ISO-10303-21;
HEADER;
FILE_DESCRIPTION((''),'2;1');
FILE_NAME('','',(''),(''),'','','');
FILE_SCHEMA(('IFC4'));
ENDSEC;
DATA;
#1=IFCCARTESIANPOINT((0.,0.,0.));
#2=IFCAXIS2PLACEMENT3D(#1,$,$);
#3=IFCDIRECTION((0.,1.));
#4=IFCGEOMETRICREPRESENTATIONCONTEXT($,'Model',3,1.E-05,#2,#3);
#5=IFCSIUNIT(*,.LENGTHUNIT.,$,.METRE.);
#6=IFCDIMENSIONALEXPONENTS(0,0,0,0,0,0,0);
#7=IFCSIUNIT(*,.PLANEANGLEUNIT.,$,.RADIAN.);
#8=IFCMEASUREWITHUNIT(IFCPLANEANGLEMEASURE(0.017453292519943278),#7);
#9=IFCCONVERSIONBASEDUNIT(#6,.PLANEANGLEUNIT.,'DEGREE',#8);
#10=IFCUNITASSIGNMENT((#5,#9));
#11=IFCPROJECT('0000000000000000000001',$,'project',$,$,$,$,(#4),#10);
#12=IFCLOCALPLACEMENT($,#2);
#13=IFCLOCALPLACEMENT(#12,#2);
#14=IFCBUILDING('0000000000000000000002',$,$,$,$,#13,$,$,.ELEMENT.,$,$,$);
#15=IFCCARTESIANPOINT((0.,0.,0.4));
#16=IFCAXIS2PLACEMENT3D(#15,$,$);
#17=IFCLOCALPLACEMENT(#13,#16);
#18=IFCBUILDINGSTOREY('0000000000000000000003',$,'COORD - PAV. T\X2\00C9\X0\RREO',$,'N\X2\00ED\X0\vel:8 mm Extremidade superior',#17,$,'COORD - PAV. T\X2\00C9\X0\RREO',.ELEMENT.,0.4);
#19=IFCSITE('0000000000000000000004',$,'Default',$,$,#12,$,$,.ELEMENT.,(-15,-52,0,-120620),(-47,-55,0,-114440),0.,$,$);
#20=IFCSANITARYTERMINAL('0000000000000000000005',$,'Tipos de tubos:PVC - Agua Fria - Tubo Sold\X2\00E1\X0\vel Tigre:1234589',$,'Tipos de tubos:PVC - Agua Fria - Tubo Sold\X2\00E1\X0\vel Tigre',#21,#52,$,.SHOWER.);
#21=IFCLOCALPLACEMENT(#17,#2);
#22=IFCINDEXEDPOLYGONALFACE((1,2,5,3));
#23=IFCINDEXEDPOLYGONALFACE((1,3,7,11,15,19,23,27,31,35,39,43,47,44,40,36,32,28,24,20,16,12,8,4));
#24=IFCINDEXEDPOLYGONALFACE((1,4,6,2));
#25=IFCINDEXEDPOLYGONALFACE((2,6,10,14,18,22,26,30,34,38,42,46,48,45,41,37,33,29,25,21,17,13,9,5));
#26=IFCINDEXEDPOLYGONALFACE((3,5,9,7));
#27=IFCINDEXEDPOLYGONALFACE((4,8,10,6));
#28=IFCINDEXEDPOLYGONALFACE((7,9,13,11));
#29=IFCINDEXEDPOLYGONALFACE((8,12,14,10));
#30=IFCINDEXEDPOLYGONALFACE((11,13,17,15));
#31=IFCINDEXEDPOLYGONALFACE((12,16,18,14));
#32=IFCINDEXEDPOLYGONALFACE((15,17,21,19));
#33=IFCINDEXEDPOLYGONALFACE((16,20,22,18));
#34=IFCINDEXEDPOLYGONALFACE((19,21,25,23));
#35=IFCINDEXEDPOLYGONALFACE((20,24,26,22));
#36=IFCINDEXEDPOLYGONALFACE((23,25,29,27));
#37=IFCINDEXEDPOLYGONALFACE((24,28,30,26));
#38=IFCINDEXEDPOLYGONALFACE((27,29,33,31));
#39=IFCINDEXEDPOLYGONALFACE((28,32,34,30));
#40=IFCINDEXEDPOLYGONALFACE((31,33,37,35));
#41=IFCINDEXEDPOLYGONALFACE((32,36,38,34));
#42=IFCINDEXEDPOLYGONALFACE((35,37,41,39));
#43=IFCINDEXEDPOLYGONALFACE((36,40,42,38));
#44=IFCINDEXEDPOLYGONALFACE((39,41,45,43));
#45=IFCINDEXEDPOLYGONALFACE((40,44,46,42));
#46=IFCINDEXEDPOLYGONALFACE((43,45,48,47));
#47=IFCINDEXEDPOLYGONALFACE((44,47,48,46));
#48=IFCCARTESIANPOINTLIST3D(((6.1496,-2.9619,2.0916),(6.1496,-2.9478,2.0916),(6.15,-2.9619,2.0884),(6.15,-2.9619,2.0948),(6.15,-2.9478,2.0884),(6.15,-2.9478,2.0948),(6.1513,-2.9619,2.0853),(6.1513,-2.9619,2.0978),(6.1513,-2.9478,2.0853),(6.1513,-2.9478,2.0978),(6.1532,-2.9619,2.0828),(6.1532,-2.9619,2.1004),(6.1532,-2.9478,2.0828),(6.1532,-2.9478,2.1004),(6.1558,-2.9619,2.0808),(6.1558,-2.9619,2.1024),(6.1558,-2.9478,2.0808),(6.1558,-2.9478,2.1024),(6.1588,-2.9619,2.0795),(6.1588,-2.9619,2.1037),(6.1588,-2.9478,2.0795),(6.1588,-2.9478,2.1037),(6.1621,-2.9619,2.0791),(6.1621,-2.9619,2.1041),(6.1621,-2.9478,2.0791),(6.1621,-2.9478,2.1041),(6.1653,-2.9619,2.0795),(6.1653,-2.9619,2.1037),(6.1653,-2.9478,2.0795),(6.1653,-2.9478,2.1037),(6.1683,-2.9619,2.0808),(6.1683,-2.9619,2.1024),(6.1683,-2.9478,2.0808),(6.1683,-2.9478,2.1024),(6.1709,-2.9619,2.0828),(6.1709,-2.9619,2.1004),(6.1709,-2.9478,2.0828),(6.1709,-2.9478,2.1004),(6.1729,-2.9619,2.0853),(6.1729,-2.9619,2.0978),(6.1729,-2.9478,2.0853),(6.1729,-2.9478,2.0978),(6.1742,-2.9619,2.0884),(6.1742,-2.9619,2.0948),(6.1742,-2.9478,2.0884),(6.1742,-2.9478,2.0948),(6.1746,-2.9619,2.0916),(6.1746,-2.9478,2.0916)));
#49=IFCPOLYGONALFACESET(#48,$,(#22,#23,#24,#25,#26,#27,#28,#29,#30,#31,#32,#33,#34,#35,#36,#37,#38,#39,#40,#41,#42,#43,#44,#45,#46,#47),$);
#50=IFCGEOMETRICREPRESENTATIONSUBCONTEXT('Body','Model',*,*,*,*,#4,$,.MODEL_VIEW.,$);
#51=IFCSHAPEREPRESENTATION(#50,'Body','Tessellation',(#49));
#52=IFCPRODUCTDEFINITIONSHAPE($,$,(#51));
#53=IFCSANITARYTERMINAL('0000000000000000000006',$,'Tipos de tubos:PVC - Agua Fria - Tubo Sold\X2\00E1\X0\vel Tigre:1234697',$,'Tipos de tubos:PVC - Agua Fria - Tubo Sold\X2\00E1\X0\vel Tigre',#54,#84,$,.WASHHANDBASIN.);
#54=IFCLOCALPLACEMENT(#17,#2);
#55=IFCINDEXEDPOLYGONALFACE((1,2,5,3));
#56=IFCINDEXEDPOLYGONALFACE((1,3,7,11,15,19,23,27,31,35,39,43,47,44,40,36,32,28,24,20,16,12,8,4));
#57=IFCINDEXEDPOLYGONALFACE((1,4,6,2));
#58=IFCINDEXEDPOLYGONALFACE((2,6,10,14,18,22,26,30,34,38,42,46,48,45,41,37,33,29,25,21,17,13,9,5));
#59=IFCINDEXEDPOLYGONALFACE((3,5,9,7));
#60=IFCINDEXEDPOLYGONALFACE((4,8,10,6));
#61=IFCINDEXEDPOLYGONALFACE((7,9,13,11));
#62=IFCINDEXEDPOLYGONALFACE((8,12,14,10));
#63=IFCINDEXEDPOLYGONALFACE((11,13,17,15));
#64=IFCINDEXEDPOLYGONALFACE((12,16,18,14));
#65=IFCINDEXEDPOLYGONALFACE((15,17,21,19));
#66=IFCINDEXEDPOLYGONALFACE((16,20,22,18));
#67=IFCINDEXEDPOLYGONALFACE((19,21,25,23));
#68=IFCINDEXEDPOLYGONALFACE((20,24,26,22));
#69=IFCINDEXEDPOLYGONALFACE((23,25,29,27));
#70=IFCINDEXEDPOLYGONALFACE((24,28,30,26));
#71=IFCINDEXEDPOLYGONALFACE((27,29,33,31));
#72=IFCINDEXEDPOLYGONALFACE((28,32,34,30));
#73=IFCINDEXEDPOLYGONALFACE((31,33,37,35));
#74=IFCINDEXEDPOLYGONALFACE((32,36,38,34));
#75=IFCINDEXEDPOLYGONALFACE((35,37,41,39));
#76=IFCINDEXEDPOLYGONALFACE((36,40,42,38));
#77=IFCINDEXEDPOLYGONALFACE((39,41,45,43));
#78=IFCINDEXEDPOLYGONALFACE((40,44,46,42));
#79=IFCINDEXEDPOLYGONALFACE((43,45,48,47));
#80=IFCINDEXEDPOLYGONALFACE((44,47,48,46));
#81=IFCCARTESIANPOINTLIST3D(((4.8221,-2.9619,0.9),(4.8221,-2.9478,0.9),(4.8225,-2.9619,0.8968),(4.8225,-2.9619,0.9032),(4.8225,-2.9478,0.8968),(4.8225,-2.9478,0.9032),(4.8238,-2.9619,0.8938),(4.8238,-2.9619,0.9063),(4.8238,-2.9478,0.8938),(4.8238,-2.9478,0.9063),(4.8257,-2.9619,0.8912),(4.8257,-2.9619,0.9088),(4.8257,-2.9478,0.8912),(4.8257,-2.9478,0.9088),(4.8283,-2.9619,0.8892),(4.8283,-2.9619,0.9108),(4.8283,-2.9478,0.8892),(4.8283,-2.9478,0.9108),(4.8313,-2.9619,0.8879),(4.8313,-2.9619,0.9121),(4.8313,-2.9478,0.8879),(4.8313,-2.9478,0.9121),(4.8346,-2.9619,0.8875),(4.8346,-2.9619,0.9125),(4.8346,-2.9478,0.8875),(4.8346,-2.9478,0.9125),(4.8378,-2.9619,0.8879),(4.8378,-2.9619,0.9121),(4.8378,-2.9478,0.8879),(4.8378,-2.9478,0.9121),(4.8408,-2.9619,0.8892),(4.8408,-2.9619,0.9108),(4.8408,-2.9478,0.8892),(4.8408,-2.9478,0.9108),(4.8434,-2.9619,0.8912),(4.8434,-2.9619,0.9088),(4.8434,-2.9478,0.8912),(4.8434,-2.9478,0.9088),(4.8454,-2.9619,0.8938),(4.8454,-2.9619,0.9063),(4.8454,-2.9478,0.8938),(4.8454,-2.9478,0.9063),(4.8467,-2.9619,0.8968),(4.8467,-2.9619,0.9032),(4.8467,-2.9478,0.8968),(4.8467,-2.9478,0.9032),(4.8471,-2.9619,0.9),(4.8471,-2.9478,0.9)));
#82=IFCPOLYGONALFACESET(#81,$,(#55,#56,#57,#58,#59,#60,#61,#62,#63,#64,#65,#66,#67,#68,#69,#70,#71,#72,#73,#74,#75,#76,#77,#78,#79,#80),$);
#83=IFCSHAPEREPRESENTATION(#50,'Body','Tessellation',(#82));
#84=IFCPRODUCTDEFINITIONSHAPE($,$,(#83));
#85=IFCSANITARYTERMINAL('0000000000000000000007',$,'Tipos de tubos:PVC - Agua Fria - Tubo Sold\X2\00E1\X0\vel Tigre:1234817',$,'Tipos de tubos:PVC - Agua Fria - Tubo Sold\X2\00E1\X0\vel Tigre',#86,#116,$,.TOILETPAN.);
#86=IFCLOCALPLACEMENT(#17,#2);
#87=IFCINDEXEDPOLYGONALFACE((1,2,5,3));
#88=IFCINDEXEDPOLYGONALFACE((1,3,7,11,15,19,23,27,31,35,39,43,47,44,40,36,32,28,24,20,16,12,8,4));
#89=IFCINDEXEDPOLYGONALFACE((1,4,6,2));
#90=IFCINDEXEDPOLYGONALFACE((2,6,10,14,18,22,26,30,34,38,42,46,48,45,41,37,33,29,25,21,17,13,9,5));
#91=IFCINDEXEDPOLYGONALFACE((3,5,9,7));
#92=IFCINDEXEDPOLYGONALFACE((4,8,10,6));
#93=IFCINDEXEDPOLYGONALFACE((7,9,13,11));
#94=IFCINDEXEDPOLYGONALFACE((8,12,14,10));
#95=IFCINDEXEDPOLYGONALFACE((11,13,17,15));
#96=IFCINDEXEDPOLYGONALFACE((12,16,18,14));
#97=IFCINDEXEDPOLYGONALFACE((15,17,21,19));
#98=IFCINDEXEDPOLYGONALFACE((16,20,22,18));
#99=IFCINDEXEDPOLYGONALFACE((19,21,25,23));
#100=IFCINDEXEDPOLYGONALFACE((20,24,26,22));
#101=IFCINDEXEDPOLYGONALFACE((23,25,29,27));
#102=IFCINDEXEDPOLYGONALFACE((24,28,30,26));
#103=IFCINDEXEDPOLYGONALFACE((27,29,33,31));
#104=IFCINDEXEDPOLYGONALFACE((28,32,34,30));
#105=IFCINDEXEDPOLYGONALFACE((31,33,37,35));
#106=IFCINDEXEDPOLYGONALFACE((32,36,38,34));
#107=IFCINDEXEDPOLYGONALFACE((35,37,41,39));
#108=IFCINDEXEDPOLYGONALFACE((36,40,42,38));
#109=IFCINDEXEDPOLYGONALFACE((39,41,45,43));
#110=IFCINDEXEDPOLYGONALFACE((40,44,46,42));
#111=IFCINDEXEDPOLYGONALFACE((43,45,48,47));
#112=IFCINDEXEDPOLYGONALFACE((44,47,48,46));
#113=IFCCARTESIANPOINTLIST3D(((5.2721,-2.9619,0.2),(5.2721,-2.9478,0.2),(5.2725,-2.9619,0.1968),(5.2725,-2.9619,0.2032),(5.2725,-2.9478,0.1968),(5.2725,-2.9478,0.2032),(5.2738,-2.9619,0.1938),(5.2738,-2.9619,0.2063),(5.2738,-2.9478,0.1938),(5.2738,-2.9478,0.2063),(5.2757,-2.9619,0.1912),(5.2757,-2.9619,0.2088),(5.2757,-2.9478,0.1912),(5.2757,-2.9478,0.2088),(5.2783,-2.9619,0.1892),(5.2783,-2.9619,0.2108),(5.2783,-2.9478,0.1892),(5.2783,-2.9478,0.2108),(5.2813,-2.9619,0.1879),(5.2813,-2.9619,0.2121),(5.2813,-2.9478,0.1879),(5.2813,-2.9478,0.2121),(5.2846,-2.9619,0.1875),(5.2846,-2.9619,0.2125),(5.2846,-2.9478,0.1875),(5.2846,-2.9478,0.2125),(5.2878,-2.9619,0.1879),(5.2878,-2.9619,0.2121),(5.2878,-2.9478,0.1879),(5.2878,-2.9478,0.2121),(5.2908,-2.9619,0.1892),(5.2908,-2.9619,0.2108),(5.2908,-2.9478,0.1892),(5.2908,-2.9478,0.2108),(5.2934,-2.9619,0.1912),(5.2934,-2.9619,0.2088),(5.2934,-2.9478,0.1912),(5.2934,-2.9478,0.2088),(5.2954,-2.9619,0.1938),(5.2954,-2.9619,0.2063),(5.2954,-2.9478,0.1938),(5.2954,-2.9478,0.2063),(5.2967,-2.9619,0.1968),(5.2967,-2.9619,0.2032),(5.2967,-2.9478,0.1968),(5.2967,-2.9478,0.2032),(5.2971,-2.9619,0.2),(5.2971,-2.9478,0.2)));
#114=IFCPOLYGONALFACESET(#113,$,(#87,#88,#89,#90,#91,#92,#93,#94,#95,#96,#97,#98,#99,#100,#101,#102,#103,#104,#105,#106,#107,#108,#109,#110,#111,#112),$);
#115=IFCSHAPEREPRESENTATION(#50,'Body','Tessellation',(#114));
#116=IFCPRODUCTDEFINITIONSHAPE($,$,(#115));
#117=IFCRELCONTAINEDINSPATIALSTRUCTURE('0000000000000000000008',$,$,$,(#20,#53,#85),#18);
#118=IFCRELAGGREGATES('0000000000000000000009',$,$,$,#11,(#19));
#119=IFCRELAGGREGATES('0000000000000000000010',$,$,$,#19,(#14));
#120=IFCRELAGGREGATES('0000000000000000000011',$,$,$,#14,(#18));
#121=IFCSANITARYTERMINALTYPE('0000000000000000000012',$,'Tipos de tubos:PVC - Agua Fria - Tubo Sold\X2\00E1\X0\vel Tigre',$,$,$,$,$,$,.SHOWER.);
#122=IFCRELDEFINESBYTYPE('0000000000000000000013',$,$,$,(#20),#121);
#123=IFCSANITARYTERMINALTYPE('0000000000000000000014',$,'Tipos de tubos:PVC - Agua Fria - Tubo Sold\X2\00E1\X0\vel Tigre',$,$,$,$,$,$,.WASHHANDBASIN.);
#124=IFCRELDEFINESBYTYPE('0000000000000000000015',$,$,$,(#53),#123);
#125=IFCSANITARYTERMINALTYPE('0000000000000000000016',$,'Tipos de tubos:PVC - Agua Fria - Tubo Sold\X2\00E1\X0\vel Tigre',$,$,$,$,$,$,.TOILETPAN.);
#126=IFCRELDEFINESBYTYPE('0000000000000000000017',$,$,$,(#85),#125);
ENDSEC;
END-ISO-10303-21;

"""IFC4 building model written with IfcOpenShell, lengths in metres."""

from ifc_helpers import new_model, entity, si_unit, converted_unit, direction, frame, origin, place, context, subcontext, project, spatial, arc, indexed_curve, outline, extrude, type_object, element, save


model = new_model("IFC4")

# Units and contexts
model_context = context("Model", 3, precision=1e-05, world=origin(), true_north=direction((0.0, 1.0)))
body_context = subcontext(model_context, "Body", "Model", "MODEL_VIEW")
ifc_project = project(units=[si_unit("LENGTHUNIT", "METRE"), converted_unit("PLANEANGLEUNIT", "DEGREE", entity("IfcPlaneAngleMeasure", 0.017453292519943278), si_unit("PLANEANGLEUNIT", "RADIAN"), dimensions=[0, 0, 0, 0, 0, 0, 0])], contexts=[model_context])

# Site, building, storey
site_placement = place(None, origin())
site = spatial("IfcSite", under=ifc_project, at=site_placement, Name="Default", CompositionType="ELEMENT", RefLatitude=(-15, -52, 0, -120620), RefLongitude=(-47, -55, 0, -114440), RefElevation=0.0)
building_placement = place(site_placement, origin())
building = spatial("IfcBuilding", under=site, at=building_placement, CompositionType="ELEMENT")
storey_placement = place(building_placement, frame((0.0, 0.0, 0.4)))
storey = spatial("IfcBuildingStorey", under=building, at=storey_placement, Name="COORD - PAV. TÉRREO", ObjectType="Nível:8 mm Extremidade superior", LongName="COORD - PAV. TÉRREO", CompositionType="ELEMENT", Elevation=0.4)

# Sanitary terminals
sanitary_terminal_type_1 = type_object("IfcSanitaryTerminalType", Name="Tipos de tubos:PVC - Agua Fria - Tubo Soldável Tigre", PredefinedType="SHOWER")
sanitary_terminal_1_placement = place(storey_placement, origin())
element("IfcSanitaryTerminal", 1, at=sanitary_terminal_1_placement, inside=storey, type_object=sanitary_terminal_type_1, Name="Tipos de tubos:PVC - Agua Fria - Tubo Soldável Tigre:1234589", ObjectType="Tipos de tubos:PVC - Agua Fria - Tubo Soldável Tigre", PredefinedType="SHOWER", context=body_context, shape_type="SweptSolid", body=[
    extrude(outline(indexed_curve([(0.0125, 0.0), (0.0088, 0.0088), (0.0, 0.0125), (-0.0088, 0.0088), (-0.0125, 0.0), (-0.0088, -0.0088), (0.0, -0.0125), (0.0088, -0.0088)], segments=[arc(1, 2, 3), arc(3, 4, 5), arc(5, 6, 7), arc(7, 8, 1)], self_intersect=False)), frame((6.1621, -2.9619, 2.0916), z_axis=(0.0, 1.0, 0.0), x_axis=(1.0, 0.0, 0.0)), (0.0, 0.0, 1.0), 0.0141),
])
sanitary_terminal_type_2 = type_object("IfcSanitaryTerminalType", Name="Tipos de tubos:PVC - Agua Fria - Tubo Soldável Tigre", PredefinedType="WASHHANDBASIN")
sanitary_terminal_2_placement = place(storey_placement, origin())
element("IfcSanitaryTerminal", 2, at=sanitary_terminal_2_placement, inside=storey, type_object=sanitary_terminal_type_2, Name="Tipos de tubos:PVC - Agua Fria - Tubo Soldável Tigre:1234697", ObjectType="Tipos de tubos:PVC - Agua Fria - Tubo Soldável Tigre", PredefinedType="WASHHANDBASIN", context=body_context, shape_type="SweptSolid", body=[
    extrude(outline(indexed_curve([(0.0125, 0.0), (0.0088, 0.0088), (0.0, 0.0125), (-0.0088, 0.0088), (-0.0125, 0.0), (-0.0088, -0.0088), (0.0, -0.0125), (0.0088, -0.0088)], segments=[arc(1, 2, 3), arc(3, 4, 5), arc(5, 6, 7), arc(7, 8, 1)], self_intersect=False)), frame((4.8346, -2.9619, 0.9), z_axis=(0.0, 1.0, 0.0), x_axis=(-1.0, 0.0, 0.0)), (0.0, 0.0, 1.0), 0.0141),
])
sanitary_terminal_type_3 = type_object("IfcSanitaryTerminalType", Name="Tipos de tubos:PVC - Agua Fria - Tubo Soldável Tigre", PredefinedType="TOILETPAN")
sanitary_terminal_3_placement = place(storey_placement, origin())
element("IfcSanitaryTerminal", 3, at=sanitary_terminal_3_placement, inside=storey, type_object=sanitary_terminal_type_3, Name="Tipos de tubos:PVC - Agua Fria - Tubo Soldável Tigre:1234817", ObjectType="Tipos de tubos:PVC - Agua Fria - Tubo Soldável Tigre", PredefinedType="TOILETPAN", context=body_context, shape_type="SweptSolid", body=[
    extrude(outline(indexed_curve([(0.0125, 0.0), (0.0088, 0.0088), (0.0, 0.0125), (-0.0088, 0.0088), (-0.0125, 0.0), (-0.0088, -0.0088), (0.0, -0.0125), (0.0088, -0.0088)], segments=[arc(1, 2, 3), arc(3, 4, 5), arc(5, 6, 7), arc(7, 8, 1)], self_intersect=False)), frame((5.2846, -2.9619, 0.2), z_axis=(0.0, 1.0, 0.0), x_axis=(-1.0, 0.0, 0.0)), (0.0, 0.0, 1.0), 0.0141),
])

save(model, "model.ifc")
